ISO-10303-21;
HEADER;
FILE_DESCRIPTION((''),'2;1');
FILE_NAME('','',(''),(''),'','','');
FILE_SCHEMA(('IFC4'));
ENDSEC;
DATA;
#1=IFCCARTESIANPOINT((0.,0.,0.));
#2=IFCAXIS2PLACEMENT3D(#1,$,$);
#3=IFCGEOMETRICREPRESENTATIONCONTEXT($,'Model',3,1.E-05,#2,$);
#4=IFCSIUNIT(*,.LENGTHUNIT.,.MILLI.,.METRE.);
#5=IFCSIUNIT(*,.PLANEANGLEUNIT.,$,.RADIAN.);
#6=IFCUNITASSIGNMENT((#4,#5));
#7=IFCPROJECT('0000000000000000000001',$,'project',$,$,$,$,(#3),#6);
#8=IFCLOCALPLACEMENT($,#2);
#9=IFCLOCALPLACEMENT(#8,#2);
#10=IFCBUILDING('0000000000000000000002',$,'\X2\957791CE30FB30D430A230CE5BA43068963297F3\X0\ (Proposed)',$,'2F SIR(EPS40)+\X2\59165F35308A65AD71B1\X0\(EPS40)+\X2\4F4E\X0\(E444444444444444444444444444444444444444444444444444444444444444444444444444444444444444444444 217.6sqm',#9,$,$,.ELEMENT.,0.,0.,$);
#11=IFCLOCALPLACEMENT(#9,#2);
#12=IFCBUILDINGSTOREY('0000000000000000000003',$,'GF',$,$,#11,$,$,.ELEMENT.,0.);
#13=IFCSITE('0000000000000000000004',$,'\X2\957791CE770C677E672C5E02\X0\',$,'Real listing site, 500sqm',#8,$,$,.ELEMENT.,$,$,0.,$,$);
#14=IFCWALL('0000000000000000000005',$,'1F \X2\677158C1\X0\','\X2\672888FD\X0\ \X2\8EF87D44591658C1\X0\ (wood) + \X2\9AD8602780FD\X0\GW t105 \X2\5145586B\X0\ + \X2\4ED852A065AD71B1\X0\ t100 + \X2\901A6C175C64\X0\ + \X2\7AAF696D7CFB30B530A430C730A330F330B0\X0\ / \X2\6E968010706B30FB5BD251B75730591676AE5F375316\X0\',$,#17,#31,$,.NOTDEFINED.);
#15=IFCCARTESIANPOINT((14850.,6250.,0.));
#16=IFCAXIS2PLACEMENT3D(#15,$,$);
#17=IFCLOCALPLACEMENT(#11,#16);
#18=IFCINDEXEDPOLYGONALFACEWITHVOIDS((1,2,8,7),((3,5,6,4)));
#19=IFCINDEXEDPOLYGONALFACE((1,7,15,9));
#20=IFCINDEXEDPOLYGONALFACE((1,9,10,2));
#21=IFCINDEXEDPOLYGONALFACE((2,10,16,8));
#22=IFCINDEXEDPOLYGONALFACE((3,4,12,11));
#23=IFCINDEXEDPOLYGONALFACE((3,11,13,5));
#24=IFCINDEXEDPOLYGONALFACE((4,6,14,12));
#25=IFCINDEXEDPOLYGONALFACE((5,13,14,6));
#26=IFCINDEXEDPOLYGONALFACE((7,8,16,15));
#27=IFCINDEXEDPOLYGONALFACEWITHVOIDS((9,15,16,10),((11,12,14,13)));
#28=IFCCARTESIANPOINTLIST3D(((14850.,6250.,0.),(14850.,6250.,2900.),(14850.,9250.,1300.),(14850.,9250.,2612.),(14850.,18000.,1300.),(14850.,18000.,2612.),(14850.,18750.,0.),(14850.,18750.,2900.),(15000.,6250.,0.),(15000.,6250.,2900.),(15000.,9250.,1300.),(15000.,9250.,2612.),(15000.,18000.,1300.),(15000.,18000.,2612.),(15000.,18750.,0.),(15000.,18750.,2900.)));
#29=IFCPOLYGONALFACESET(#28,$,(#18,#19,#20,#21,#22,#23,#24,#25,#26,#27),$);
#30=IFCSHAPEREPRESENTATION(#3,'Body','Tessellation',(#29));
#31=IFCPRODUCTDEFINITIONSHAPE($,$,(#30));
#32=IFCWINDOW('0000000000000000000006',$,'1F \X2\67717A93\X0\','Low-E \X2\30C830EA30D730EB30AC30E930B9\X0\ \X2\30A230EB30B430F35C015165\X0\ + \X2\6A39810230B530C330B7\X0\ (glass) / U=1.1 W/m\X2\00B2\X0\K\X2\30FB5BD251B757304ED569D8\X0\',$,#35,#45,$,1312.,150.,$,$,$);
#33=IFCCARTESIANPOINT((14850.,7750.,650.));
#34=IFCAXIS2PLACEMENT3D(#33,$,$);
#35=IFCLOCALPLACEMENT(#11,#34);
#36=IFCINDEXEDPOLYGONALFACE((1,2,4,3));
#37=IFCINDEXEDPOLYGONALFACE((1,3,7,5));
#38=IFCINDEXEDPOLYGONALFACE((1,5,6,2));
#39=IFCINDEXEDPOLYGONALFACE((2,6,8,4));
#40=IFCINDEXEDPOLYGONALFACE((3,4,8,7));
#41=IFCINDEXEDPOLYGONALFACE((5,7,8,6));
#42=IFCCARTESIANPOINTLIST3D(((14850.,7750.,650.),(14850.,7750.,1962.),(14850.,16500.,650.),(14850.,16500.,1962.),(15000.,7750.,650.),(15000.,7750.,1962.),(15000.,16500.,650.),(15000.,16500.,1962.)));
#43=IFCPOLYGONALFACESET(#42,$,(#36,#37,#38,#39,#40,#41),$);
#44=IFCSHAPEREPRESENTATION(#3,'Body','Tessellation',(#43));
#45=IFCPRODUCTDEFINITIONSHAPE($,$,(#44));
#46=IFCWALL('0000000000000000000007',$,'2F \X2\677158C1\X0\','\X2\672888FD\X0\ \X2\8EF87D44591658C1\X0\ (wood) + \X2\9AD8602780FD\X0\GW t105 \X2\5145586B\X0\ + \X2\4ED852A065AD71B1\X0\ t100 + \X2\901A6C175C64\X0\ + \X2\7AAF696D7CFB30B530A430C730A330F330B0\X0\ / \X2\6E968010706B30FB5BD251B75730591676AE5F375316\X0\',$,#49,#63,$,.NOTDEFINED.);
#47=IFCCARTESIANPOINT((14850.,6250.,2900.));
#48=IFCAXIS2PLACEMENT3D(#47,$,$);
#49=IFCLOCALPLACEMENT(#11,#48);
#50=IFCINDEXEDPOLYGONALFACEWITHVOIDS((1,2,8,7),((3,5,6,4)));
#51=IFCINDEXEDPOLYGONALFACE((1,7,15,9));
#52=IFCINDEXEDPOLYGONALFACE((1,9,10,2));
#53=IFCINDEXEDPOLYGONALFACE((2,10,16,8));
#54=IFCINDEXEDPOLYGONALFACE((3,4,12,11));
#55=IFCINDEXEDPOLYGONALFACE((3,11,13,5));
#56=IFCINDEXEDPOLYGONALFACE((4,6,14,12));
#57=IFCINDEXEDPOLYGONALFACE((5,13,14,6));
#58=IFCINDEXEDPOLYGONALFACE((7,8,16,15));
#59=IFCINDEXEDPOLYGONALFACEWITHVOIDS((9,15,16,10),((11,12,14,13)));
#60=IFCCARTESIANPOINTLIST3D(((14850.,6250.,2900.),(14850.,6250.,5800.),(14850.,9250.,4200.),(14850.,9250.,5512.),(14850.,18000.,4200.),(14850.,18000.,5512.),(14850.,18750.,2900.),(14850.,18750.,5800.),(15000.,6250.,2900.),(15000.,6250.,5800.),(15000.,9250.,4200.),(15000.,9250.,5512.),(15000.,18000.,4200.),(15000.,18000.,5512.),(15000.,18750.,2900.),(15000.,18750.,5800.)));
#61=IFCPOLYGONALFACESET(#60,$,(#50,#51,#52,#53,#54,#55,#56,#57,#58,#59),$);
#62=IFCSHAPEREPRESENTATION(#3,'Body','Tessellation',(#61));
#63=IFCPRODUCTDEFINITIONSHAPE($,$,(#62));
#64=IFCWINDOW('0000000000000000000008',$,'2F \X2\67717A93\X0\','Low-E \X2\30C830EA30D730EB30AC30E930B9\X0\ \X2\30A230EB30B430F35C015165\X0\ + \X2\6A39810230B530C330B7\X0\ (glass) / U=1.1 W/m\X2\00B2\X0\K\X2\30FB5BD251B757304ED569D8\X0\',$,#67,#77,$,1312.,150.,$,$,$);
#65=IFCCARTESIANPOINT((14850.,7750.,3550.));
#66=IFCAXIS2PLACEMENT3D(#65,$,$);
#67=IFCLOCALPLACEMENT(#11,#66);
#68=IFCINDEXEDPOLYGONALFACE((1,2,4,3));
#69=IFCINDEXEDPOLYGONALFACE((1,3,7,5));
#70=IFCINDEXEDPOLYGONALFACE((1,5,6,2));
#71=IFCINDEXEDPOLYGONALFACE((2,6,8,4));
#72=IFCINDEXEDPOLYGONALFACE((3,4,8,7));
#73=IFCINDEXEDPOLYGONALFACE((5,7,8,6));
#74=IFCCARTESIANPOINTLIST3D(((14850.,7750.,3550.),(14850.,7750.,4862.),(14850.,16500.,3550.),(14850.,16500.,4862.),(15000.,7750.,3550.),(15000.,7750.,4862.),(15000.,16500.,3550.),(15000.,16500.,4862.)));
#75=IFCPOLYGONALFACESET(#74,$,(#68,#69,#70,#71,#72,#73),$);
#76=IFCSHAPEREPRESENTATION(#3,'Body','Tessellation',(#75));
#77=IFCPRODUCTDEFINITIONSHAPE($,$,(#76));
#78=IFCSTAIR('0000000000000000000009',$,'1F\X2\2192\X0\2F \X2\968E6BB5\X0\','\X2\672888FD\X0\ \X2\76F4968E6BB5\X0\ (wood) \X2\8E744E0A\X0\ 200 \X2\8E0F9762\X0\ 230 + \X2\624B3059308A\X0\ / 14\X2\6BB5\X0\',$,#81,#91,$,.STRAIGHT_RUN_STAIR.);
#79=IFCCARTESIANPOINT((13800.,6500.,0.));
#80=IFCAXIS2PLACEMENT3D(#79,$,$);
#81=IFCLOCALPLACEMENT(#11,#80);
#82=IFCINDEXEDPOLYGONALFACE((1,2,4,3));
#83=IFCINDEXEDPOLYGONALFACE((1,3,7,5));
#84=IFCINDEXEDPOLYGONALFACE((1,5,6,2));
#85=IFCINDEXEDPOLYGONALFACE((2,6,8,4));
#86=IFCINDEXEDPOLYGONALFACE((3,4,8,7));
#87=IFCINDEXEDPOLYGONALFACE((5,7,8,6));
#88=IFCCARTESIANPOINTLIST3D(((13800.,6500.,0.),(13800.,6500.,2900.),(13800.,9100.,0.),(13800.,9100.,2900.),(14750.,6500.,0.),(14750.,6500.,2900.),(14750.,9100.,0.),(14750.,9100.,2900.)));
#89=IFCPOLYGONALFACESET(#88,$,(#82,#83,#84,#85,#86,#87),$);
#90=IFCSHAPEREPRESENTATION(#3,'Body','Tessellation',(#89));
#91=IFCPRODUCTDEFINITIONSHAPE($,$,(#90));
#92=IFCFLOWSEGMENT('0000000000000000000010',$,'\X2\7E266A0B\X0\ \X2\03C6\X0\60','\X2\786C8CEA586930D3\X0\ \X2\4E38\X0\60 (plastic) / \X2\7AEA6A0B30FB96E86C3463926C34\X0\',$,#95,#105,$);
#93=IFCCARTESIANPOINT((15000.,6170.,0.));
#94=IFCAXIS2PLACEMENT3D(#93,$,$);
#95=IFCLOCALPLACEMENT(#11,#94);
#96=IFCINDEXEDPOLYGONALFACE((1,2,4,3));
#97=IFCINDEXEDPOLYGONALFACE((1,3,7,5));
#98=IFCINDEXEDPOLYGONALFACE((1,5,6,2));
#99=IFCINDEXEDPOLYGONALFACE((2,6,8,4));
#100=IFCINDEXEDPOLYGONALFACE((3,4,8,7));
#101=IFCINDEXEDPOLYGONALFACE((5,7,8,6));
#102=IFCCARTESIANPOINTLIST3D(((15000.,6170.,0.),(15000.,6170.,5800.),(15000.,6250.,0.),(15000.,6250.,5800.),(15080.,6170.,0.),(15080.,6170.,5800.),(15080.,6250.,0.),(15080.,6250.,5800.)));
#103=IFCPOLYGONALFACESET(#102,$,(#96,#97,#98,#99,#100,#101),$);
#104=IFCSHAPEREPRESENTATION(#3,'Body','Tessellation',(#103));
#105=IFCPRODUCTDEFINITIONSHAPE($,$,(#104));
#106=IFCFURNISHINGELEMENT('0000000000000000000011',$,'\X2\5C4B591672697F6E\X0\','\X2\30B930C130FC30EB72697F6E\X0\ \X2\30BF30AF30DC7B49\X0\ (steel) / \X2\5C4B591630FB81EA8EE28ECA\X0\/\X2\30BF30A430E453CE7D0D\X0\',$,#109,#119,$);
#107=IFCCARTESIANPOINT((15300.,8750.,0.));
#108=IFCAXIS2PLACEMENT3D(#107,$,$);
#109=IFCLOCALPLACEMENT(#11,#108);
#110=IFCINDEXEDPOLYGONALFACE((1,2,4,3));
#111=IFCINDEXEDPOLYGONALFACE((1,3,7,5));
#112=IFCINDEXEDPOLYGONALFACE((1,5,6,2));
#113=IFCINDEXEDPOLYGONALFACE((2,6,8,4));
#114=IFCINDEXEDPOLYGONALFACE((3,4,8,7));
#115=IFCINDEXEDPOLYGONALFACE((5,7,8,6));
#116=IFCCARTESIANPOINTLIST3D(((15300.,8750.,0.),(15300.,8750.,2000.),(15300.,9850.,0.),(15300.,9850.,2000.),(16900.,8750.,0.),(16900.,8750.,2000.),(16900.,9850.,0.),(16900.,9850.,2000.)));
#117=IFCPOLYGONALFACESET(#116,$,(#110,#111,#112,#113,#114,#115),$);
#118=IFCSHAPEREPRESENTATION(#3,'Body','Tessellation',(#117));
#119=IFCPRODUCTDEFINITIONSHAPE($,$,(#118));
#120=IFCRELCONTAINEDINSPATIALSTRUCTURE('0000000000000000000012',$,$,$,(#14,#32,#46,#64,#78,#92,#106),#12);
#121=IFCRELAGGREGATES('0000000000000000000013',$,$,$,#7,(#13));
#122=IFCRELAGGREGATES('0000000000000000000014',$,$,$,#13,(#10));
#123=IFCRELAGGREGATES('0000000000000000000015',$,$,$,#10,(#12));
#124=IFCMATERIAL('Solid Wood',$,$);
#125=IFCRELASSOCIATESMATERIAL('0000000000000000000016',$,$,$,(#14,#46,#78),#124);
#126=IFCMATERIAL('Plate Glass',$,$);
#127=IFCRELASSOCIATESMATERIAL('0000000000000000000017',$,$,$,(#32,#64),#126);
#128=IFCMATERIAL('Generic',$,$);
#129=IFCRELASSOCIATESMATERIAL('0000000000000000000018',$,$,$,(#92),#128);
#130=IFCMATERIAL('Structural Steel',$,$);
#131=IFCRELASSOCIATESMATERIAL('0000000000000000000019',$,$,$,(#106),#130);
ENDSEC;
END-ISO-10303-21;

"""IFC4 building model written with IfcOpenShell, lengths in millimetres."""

from ifc_helpers import new_model, si_unit, frame, frame_2d, origin, place, context, project, spatial, rectangle, extrude, material, element, fill, save


model = new_model("IFC4")

# Units and contexts
model_context = context("Model", 3, precision=1e-05, world=origin())
ifc_project = project(units=[si_unit("LENGTHUNIT", "METRE", prefix="MILLI"), si_unit("PLANEANGLEUNIT", "RADIAN")], contexts=[model_context])

# Site, building, storey
site_placement = place(None, origin())
site = spatial("IfcSite", under=ifc_project, at=site_placement, Name="長野県松本市", ObjectType="Real listing site, 500sqm", CompositionType="ELEMENT", RefElevation=0.0)
building_placement = place(site_placement, origin())
building = spatial("IfcBuilding", under=site, at=building_placement, Name="長野・ピアノ室と防音 (Proposed)", ObjectType="2F SIR(EPS40)+外張り断熱(EPS40)+低(E444444444444444444444444444444444444444444444444444444444444444444444444444444444444444444444 217.6sqm", CompositionType="ELEMENT", ElevationOfRefHeight=0.0, ElevationOfTerrain=0.0)
storey_placement = place(building_placement, origin())
storey = spatial("IfcBuildingStorey", under=building, at=storey_placement, Name="GF", CompositionType="ELEMENT", Elevation=0.0)

# Shared definitions
ifc_material_1 = material(Name="Solid Wood")

# Walls, openings, windows
wall_1_placement = place(storey_placement, frame((14850.0, 6250.0, 0.0)))
wall_1 = element("IfcWall", 1, at=wall_1_placement, inside=storey, material=ifc_material_1, Name="1F 東壁", Description="木製 軸組外壁 (wood) + 高性能GW t105 充填 + 付加断熱 t100 + 通気層 + 窯業系サイディング / 準耐火・寒冷地外皮強化", PredefinedType="NOTDEFINED", context=model_context, shape_type="SweptSolid", body=[
    extrude(rectangle(XDim=150.0, YDim=12500.0, at=frame_2d((75.0, 6250.0))), frame((14850.0, 6250.0, 0.0)), (0.0, 0.0, 1.0), 2900.0),
])
opening_1_placement = place(storey_placement, frame((14850.0, 7750.0, 650.0)))
opening_1 = element("IfcOpeningElement", 2, at=opening_1_placement, cuts=wall_1, PredefinedType="NOTDEFINED", context=model_context, shape_type="SweptSolid", body=[
    extrude(rectangle(XDim=150.0, YDim=8750.0, at=frame_2d((75.0, 4375.0))), frame((14850.0, 7750.0, 650.0)), (0.0, 0.0, 1.0), 1312.0),
])
ifc_material_2 = material(Name="Plate Glass")
window_1_placement = place(storey_placement, frame((14850.0, 7750.0, 650.0)))
window_1 = element("IfcWindow", 3, at=window_1_placement, inside=storey, material=ifc_material_2, Name="1F 東窓", Description="Low-E トリプルガラス アルゴン封入 + 樹脂サッシ (glass) / U=1.1 W/m²K・寒冷地仕様", OverallHeight=1312.0, OverallWidth=150.0, context=model_context, shape_type="SweptSolid", body=[
    extrude(rectangle(XDim=150.0, YDim=8750.0, at=frame_2d((75.0, 4375.0))), frame((14850.0, 7750.0, 650.0)), (0.0, 0.0, 1.0), 1312.0),
])
fill(opening_1, window_1)
wall_2_placement = place(storey_placement, frame((14850.0, 6250.0, 2900.0)))
wall_2 = element("IfcWall", 4, at=wall_2_placement, inside=storey, material=ifc_material_1, Name="2F 東壁", Description="木製 軸組外壁 (wood) + 高性能GW t105 充填 + 付加断熱 t100 + 通気層 + 窯業系サイディング / 準耐火・寒冷地外皮強化", PredefinedType="NOTDEFINED", context=model_context, shape_type="SweptSolid", body=[
    extrude(rectangle(XDim=150.0, YDim=12500.0, at=frame_2d((75.0, 6250.0))), frame((14850.0, 6250.0, 2900.0)), (0.0, 0.0, 1.0), 2900.0),
])
opening_2_placement = place(storey_placement, frame((14850.0, 7750.0, 3550.0)))
opening_2 = element("IfcOpeningElement", 5, at=opening_2_placement, cuts=wall_2, PredefinedType="NOTDEFINED", context=model_context, shape_type="SweptSolid", body=[
    extrude(rectangle(XDim=150.0, YDim=8750.0, at=frame_2d((75.0, 4375.0))), frame((14850.0, 7750.0, 3550.0)), (0.0, 0.0, 1.0), 1312.0),
])
window_2_placement = place(storey_placement, frame((14850.0, 7750.0, 3550.0)))
window_2 = element("IfcWindow", 6, at=window_2_placement, inside=storey, material=ifc_material_2, Name="2F 東窓", Description="Low-E トリプルガラス アルゴン封入 + 樹脂サッシ (glass) / U=1.1 W/m²K・寒冷地仕様", OverallHeight=1312.0, OverallWidth=150.0, context=model_context, shape_type="SweptSolid", body=[
    extrude(rectangle(XDim=150.0, YDim=8750.0, at=frame_2d((75.0, 4375.0))), frame((14850.0, 7750.0, 3550.0)), (0.0, 0.0, 1.0), 1312.0),
])
fill(opening_2, window_2)

# Stair
stair_placement = place(storey_placement, frame((13800.0, 6500.0, 0.0)))
element("IfcStair", 7, at=stair_placement, inside=storey, material=ifc_material_1, Name="1F→2F 階段", Description="木製 直階段 (wood) 蹴上 200 踏面 230 + 手すり / 14段", PredefinedType="STRAIGHT_RUN_STAIR", context=model_context, shape_type="SweptSolid", body=[
    extrude(rectangle(XDim=950.0, YDim=2600.0, at=frame_2d((475.0, 1300.0))), frame((13800.0, 6500.0, 0.0)), (0.0, 0.0, 1.0), 2900.0),
])

# Flow segment
ifc_material_3 = material(Name="Generic")
flow_segment_placement = place(storey_placement, frame((15000.0, 6170.0, 0.0)))
element("IfcFlowSegment", 8, at=flow_segment_placement, inside=storey, material=ifc_material_3, Name="縦樋 φ60", Description="硬質塩ビ 丸60 (plastic) / 竪樋・雨水排水", context=model_context, shape_type="SweptSolid", body=[
    extrude(rectangle(XDim=80.0, YDim=80.0, at=frame_2d((40.0, 40.0))), frame((15000.0, 6170.0, 0.0)), (0.0, 0.0, 1.0), 5800.0),
])

# Furnishing element
ifc_material_4 = material(Name="Structural Steel")
furnishing_placement = place(storey_placement, frame((15300.0, 8750.0, 0.0)))
element("IfcFurnishingElement", 9, at=furnishing_placement, inside=storey, material=ifc_material_4, Name="屋外物置", Description="スチール物置 タクボ等 (steel) / 屋外・自転車/タイヤ収納", context=model_context, shape_type="SweptSolid", body=[
    extrude(rectangle(XDim=1600.0, YDim=1100.0, at=frame_2d((800.0, 550.0))), frame((15300.0, 8750.0, 0.0)), (0.0, 0.0, 1.0), 2000.0),
])

save(model, "model.ifc")
